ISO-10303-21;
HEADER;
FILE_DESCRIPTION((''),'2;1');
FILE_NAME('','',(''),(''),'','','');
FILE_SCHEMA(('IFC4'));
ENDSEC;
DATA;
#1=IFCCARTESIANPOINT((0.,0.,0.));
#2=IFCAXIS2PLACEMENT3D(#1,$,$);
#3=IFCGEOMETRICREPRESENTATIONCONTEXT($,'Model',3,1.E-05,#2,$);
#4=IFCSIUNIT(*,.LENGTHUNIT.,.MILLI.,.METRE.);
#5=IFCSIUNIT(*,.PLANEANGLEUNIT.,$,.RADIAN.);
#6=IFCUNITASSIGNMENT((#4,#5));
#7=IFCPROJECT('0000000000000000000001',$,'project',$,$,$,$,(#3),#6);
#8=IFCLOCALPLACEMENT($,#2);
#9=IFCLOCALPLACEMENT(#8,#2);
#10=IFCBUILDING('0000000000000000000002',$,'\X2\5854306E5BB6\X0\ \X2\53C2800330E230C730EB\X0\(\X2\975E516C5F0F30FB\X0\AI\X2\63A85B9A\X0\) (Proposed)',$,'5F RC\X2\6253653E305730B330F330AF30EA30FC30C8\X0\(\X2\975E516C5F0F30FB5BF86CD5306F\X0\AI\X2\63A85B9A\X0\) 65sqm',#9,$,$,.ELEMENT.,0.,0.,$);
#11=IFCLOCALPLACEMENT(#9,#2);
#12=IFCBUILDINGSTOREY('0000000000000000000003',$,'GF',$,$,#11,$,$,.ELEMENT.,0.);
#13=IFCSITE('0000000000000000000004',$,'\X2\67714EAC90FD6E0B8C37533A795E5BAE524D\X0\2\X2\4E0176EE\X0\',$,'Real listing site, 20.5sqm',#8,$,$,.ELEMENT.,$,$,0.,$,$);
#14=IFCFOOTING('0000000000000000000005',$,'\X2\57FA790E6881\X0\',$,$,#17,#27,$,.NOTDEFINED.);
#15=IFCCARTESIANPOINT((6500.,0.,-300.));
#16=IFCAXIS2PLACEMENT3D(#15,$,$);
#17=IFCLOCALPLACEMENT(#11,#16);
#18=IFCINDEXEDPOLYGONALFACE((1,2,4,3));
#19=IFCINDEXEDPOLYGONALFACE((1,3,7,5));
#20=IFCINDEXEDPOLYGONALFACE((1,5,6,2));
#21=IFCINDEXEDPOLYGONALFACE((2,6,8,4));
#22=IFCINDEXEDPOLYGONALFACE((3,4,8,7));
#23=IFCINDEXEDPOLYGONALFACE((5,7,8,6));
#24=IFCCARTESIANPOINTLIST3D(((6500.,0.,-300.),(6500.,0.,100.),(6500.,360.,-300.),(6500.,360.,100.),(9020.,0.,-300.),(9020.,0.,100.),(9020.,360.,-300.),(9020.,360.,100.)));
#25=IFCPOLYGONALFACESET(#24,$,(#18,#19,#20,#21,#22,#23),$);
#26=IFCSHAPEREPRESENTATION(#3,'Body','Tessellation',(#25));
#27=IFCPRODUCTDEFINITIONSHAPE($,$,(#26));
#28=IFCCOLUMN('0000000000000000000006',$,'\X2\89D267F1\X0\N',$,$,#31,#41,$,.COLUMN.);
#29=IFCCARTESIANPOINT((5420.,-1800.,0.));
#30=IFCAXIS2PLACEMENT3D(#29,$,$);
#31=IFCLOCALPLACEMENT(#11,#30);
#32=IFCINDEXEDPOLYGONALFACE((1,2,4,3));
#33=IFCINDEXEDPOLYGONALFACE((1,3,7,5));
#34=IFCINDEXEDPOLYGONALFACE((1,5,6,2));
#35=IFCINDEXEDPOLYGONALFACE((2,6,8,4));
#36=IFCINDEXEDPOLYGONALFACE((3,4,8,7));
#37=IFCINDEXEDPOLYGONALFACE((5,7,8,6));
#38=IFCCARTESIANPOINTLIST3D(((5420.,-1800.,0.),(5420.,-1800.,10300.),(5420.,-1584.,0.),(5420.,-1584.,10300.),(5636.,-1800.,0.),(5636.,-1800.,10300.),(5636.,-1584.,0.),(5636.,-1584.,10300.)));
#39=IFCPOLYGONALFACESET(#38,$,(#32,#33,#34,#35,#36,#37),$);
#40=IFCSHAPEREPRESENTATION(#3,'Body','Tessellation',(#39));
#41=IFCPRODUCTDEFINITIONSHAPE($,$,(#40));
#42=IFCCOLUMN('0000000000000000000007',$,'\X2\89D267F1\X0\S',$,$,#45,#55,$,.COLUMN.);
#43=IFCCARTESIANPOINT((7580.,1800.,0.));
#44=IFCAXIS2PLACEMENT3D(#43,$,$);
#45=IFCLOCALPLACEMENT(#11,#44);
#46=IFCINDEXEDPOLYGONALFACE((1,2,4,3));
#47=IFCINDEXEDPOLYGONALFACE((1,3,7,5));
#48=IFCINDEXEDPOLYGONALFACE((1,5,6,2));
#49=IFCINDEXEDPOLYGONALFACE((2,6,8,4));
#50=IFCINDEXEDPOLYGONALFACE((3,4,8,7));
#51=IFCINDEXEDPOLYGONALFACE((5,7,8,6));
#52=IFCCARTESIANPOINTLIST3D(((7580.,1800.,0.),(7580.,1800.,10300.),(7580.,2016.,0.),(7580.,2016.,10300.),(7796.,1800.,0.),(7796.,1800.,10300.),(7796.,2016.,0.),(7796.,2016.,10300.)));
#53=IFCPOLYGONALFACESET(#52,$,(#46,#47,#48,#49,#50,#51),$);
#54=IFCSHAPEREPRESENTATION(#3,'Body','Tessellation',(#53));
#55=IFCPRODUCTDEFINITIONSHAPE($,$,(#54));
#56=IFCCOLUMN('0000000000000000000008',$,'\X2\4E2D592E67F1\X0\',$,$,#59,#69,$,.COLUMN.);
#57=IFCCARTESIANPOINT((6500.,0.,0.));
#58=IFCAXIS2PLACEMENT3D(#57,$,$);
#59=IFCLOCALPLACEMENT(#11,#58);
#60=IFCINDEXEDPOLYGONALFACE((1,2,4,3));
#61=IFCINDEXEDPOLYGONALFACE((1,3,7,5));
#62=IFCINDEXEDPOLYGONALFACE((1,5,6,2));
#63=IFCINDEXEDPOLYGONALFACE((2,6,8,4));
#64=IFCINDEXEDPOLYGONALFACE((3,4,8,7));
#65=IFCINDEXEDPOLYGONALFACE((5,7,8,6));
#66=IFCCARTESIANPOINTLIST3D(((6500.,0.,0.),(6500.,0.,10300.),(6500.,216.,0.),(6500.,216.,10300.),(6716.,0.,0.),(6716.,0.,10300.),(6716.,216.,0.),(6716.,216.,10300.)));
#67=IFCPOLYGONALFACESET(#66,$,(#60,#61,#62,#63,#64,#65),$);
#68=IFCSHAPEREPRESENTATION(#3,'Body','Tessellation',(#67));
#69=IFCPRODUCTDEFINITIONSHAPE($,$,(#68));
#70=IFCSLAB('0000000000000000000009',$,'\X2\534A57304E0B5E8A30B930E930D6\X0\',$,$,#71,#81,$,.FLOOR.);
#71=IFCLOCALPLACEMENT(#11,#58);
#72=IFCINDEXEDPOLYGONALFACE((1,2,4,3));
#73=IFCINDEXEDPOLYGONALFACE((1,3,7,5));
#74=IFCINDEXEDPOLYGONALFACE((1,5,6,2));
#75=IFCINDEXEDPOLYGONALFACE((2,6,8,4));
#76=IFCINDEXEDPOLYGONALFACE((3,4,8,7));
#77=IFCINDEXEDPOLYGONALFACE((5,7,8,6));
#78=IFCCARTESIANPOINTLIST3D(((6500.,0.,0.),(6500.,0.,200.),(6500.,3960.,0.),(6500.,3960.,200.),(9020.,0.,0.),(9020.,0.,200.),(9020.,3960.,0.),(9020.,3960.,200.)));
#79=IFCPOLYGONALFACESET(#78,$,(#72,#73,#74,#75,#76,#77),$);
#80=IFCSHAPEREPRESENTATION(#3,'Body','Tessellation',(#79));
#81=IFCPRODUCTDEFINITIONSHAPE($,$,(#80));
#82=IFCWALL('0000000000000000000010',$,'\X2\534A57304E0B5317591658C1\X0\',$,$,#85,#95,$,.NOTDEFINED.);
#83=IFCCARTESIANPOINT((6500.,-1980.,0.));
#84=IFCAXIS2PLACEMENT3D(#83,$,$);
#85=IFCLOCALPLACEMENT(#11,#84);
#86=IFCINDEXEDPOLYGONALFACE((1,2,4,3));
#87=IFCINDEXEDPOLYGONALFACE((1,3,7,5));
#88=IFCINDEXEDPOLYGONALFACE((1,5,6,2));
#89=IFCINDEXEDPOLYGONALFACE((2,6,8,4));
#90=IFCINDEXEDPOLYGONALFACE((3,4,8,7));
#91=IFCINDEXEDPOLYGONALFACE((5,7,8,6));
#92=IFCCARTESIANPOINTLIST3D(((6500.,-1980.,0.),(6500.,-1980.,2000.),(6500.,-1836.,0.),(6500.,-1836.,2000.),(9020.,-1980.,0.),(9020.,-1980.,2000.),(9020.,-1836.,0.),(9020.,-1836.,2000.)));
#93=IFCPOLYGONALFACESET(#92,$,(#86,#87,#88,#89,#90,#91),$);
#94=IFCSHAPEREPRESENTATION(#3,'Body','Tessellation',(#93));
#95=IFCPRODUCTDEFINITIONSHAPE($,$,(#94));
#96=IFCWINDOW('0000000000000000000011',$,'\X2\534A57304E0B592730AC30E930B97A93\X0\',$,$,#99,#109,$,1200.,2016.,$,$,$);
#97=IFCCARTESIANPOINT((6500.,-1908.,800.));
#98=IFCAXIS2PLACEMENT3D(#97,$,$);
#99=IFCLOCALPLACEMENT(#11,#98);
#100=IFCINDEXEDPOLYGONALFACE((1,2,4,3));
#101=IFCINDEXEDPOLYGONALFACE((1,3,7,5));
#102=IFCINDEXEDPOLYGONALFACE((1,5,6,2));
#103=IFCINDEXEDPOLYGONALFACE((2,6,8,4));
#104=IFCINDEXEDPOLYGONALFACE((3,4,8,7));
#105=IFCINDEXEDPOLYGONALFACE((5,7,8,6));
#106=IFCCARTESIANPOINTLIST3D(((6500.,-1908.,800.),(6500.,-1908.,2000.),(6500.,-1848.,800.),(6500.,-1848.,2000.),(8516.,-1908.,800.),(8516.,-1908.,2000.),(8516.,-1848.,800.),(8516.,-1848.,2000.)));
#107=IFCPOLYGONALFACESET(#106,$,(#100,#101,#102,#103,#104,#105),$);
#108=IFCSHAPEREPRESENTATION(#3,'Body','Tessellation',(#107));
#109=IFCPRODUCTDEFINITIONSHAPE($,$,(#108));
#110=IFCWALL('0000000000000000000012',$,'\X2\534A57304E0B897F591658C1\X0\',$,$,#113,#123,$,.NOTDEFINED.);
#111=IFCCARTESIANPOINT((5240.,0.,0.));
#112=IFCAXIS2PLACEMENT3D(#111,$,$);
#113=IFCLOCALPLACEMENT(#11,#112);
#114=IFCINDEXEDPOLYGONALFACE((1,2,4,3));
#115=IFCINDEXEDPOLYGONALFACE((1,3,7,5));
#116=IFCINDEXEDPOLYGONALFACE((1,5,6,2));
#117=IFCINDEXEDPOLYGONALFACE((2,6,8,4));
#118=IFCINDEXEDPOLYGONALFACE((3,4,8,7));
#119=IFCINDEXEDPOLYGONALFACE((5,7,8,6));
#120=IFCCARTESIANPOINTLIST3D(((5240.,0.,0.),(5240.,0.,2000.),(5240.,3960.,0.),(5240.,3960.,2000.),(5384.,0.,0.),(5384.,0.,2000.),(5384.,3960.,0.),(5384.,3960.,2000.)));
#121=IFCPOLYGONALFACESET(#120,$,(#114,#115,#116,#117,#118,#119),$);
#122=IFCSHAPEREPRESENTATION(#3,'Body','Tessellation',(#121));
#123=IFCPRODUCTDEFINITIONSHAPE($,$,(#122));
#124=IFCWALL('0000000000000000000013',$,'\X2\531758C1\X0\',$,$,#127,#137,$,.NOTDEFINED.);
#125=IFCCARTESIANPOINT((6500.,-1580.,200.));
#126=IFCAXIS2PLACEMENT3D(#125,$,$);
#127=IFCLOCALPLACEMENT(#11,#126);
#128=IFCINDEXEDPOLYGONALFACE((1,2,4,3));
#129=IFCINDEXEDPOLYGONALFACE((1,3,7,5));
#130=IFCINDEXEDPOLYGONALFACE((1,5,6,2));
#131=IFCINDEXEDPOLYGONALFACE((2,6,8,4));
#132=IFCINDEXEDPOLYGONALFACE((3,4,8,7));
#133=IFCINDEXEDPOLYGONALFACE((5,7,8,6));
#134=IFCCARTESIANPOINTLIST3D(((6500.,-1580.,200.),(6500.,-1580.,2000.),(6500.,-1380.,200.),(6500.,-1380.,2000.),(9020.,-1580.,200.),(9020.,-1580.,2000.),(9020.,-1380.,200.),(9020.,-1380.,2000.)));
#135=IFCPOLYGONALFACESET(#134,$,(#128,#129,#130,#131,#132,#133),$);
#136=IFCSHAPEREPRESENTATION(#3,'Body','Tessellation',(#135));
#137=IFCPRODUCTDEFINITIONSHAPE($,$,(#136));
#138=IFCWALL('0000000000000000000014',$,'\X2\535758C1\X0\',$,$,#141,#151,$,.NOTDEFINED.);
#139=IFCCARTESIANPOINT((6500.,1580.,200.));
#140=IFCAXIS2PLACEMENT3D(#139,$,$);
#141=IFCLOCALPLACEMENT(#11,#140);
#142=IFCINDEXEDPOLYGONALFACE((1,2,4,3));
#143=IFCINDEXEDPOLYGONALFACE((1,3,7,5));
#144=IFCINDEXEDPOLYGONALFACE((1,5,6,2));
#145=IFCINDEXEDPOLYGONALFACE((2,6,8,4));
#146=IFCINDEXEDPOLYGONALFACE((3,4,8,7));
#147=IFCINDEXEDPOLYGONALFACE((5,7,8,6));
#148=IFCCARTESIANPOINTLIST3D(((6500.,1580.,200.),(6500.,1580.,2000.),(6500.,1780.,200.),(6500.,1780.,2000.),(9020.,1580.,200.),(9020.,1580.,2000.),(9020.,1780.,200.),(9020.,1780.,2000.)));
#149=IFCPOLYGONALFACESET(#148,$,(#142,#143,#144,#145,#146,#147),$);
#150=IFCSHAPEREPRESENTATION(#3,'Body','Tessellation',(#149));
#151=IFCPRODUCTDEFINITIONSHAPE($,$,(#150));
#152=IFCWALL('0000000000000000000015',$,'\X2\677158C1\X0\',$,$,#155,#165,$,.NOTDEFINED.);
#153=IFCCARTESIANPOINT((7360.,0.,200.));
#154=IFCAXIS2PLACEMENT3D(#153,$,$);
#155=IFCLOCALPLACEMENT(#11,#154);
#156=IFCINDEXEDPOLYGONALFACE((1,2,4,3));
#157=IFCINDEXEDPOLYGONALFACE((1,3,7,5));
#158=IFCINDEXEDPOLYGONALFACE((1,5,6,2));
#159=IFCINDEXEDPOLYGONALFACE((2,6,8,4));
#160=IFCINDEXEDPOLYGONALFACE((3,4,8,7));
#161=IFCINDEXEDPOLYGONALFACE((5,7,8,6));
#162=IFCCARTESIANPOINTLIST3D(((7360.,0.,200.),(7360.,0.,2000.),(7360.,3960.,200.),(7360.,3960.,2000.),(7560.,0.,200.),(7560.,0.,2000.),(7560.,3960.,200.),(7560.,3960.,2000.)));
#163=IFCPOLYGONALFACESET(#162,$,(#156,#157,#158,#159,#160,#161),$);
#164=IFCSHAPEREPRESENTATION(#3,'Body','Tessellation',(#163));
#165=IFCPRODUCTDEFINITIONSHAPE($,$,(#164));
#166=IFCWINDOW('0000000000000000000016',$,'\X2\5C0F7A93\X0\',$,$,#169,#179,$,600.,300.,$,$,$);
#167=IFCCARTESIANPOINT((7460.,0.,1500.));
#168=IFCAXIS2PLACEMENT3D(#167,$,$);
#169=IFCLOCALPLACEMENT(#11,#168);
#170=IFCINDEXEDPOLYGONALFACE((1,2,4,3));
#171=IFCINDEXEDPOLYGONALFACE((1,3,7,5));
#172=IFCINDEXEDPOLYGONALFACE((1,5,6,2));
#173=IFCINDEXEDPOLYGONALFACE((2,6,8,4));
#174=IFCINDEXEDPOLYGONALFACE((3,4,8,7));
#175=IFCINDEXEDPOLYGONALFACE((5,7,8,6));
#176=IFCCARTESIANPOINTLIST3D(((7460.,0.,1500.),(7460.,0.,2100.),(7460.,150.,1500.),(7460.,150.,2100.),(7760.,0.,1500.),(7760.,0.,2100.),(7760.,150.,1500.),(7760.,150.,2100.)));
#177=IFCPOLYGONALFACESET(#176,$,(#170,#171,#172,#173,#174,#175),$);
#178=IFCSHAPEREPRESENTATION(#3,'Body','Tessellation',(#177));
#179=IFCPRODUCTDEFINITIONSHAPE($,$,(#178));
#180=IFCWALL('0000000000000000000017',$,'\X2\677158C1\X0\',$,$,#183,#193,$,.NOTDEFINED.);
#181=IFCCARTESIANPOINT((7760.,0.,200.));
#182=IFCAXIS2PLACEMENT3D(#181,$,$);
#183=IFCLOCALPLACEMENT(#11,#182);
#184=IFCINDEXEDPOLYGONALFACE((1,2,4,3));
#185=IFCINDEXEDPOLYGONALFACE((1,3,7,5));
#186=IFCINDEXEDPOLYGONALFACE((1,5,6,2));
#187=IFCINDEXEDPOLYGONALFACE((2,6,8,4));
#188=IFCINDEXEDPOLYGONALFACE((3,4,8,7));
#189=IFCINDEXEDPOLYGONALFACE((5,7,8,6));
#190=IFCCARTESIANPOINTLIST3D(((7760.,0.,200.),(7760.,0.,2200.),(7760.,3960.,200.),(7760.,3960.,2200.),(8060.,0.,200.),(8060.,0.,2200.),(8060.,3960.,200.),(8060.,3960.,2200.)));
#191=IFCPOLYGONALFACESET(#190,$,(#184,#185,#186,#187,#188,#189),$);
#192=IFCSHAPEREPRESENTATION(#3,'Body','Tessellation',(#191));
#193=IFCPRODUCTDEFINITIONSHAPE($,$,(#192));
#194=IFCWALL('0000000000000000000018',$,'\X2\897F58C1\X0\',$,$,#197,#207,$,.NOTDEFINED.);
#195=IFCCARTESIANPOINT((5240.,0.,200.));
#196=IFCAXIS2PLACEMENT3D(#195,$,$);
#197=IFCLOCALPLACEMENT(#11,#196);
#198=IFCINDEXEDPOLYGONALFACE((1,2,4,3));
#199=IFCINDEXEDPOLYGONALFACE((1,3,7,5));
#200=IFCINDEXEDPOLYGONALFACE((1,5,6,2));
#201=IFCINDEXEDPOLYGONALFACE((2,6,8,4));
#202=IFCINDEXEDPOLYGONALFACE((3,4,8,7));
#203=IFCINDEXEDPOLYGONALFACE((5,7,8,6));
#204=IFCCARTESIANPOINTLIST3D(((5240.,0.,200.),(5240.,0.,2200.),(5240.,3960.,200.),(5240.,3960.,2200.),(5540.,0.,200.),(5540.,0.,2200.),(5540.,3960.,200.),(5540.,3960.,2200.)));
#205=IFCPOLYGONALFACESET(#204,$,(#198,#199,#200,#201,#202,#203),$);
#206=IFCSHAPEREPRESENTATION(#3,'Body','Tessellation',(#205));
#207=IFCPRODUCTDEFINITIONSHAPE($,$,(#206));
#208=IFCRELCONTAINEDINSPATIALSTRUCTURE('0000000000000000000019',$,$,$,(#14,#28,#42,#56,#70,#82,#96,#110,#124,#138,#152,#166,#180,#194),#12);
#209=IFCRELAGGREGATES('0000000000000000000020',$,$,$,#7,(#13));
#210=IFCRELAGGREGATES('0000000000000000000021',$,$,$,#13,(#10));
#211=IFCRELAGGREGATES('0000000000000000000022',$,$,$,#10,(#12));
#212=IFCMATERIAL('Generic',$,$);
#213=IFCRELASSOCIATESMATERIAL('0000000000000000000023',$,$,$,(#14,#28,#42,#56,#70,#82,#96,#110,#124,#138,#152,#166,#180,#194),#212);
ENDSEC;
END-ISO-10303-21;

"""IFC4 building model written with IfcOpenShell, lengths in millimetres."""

from ifc_helpers import new_model, si_unit, frame, frame_2d, origin, place, context, project, spatial, rectangle, extrude, material, element, fill, save


model = new_model("IFC4")

# Units and contexts
model_context = context("Model", 3, precision=1e-05, world=origin())
ifc_project = project(units=[si_unit("LENGTHUNIT", "METRE", prefix="MILLI"), si_unit("PLANEANGLEUNIT", "RADIAN")], contexts=[model_context])

# Site, building, storey
site_placement = place(None, origin())
site = spatial("IfcSite", under=ifc_project, at=site_placement, Name="東京都渋谷区神宮前2丁目", ObjectType="Real listing site, 20.5sqm", CompositionType="ELEMENT", RefElevation=0.0)
building_placement = place(site_placement, origin())
building = spatial("IfcBuilding", under=site, at=building_placement, Name="塔の家 参考モデル(非公式・AI推定) (Proposed)", ObjectType="5F RC打放しコンクリート(非公式・寸法はAI推定) 65sqm", CompositionType="ELEMENT", ElevationOfRefHeight=0.0, ElevationOfTerrain=0.0)
storey_placement = place(building_placement, origin())
storey = spatial("IfcBuildingStorey", under=building, at=storey_placement, Name="GF", CompositionType="ELEMENT", Elevation=0.0)

# Footing
ifc_material = material(Name="Generic")
footing_1_placement = place(storey_placement, frame((6500.0, 0.0, -300.0)))
element("IfcFooting", 1, at=footing_1_placement, inside=storey, material=ifc_material, Name="基礎梁", PredefinedType="NOTDEFINED", context=model_context, shape_type="SweptSolid", body=[
    extrude(rectangle(XDim=2520.0, YDim=360.0, at=frame_2d((1260.0, 180.0))), frame((6500.0, 0.0, -300.0)), (0.0, 0.0, 1.0), 400.0),
])

# Columns
column_1_placement = place(storey_placement, frame((5420.0, -1800.0, 0.0)))
element("IfcColumn", 2, at=column_1_placement, inside=storey, material=ifc_material, Name="角柱N", PredefinedType="COLUMN", context=model_context, shape_type="SweptSolid", body=[
    extrude(rectangle(XDim=216.0, YDim=216.0, at=frame_2d((108.0, 108.0))), frame((5420.0, -1800.0, 0.0)), (0.0, 0.0, 1.0), 10300.0),
])
column_2_placement = place(storey_placement, frame((7580.0, 1800.0, 0.0)))
element("IfcColumn", 3, at=column_2_placement, inside=storey, material=ifc_material, Name="角柱S", PredefinedType="COLUMN", context=model_context, shape_type="SweptSolid", body=[
    extrude(rectangle(XDim=216.0, YDim=216.0, at=frame_2d((108.0, 108.0))), frame((7580.0, 1800.0, 0.0)), (0.0, 0.0, 1.0), 10300.0),
])
column_3_placement = place(storey_placement, frame((6500.0, 0.0, 0.0)))
element("IfcColumn", 4, at=column_3_placement, inside=storey, material=ifc_material, Name="中央柱", PredefinedType="COLUMN", context=model_context, shape_type="SweptSolid", body=[
    extrude(rectangle(XDim=216.0, YDim=216.0, at=frame_2d((108.0, 108.0))), frame((6500.0, 0.0, 0.0)), (0.0, 0.0, 1.0), 10300.0),
])

# Slab
slab_placement = place(storey_placement, frame((6500.0, 0.0, 0.0)))
element("IfcSlab", 5, at=slab_placement, inside=storey, material=ifc_material, Name="半地下床スラブ", PredefinedType="FLOOR", context=model_context, shape_type="SweptSolid", body=[
    extrude(rectangle(XDim=2520.0, YDim=3960.0, at=frame_2d((1260.0, 1980.0))), frame((6500.0, 0.0, 0.0)), (0.0, 0.0, 1.0), 200.0),
])

# Wall, opening, window
wall_1_placement = place(storey_placement, frame((6500.0, -1980.0, 0.0)))
wall_1 = element("IfcWall", 6, at=wall_1_placement, inside=storey, material=ifc_material, Name="半地下北外壁", PredefinedType="NOTDEFINED", context=model_context, shape_type="SweptSolid", body=[
    extrude(rectangle(XDim=2520.0, YDim=144.0, at=frame_2d((1260.0, 72.0))), frame((6500.0, -1980.0, 0.0)), (0.0, 0.0, 1.0), 2000.0),
])
opening_1_placement = place(storey_placement, frame((6500.0, -1908.0, 800.0)))
opening_1 = element("IfcOpeningElement", 7, at=opening_1_placement, cuts=wall_1, PredefinedType="NOTDEFINED", context=model_context, shape_type="SweptSolid", body=[
    extrude(rectangle(XDim=2016.0, YDim=60.0, at=frame_2d((1008.0, 30.0))), frame((6500.0, -1908.0, 800.0)), (0.0, 0.0, 1.0), 1200.0),
])
window_1_placement = place(storey_placement, frame((6500.0, -1908.0, 800.0)))
window_1 = element("IfcWindow", 8, at=window_1_placement, inside=storey, material=ifc_material, Name="半地下大ガラス窓", OverallHeight=1200.0, OverallWidth=2016.0, context=model_context, shape_type="SweptSolid", body=[
    extrude(rectangle(XDim=2016.0, YDim=60.0, at=frame_2d((1008.0, 30.0))), frame((6500.0, -1908.0, 800.0)), (0.0, 0.0, 1.0), 1200.0),
])
fill(opening_1, window_1)

# Walls
wall_2_placement = place(storey_placement, frame((5240.0, 0.0, 0.0)))
element("IfcWall", 9, at=wall_2_placement, inside=storey, material=ifc_material, Name="半地下西外壁", PredefinedType="NOTDEFINED", context=model_context, shape_type="SweptSolid", body=[
    extrude(rectangle(XDim=144.0, YDim=3960.0, at=frame_2d((72.0, 1980.0))), frame((5240.0, 0.0, 0.0)), (0.0, 0.0, 1.0), 2000.0),
])
wall_3_placement = place(storey_placement, frame((6500.0, -1580.0, 200.0)))
element("IfcWall", 10, at=wall_3_placement, inside=storey, material=ifc_material, Name="北壁", PredefinedType="NOTDEFINED", context=model_context, shape_type="SweptSolid", body=[
    extrude(rectangle(XDim=2520.0, YDim=200.0, at=frame_2d((1260.0, 100.0))), frame((6500.0, -1580.0, 200.0)), (0.0, 0.0, 1.0), 1800.0),
])
wall_4_placement = place(storey_placement, frame((6500.0, 1580.0, 200.0)))
element("IfcWall", 11, at=wall_4_placement, inside=storey, material=ifc_material, Name="南壁", PredefinedType="NOTDEFINED", context=model_context, shape_type="SweptSolid", body=[
    extrude(rectangle(XDim=2520.0, YDim=200.0, at=frame_2d((1260.0, 100.0))), frame((6500.0, 1580.0, 200.0)), (0.0, 0.0, 1.0), 1800.0),
])

# Wall, opening, window
wall_5_placement = place(storey_placement, frame((7360.0, 0.0, 200.0)))
wall_5 = element("IfcWall", 12, at=wall_5_placement, inside=storey, material=ifc_material, Name="東壁", PredefinedType="NOTDEFINED", context=model_context, shape_type="SweptSolid", body=[
    extrude(rectangle(XDim=200.0, YDim=3960.0, at=frame_2d((100.0, 1980.0))), frame((7360.0, 0.0, 200.0)), (0.0, 0.0, 1.0), 1800.0),
])
opening_2_placement = place(storey_placement, frame((7460.0, 0.0, 1500.0)))
opening_2 = element("IfcOpeningElement", 13, at=opening_2_placement, cuts=wall_5, PredefinedType="NOTDEFINED", context=model_context, shape_type="SweptSolid", body=[
    extrude(rectangle(XDim=300.0, YDim=150.0, at=frame_2d((150.0, 75.0))), frame((7460.0, 0.0, 1500.0)), (0.0, 0.0, 1.0), 600.0),
])
window_2_placement = place(storey_placement, frame((7460.0, 0.0, 1500.0)))
window_2 = element("IfcWindow", 14, at=window_2_placement, inside=storey, material=ifc_material, Name="小窓", OverallHeight=600.0, OverallWidth=300.0, context=model_context, shape_type="SweptSolid", body=[
    extrude(rectangle(XDim=300.0, YDim=150.0, at=frame_2d((150.0, 75.0))), frame((7460.0, 0.0, 1500.0)), (0.0, 0.0, 1.0), 600.0),
])
fill(opening_2, window_2)

# Walls
wall_6_placement = place(storey_placement, frame((7760.0, 0.0, 200.0)))
element("IfcWall", 15, at=wall_6_placement, inside=storey, material=ifc_material, Name="東壁", PredefinedType="NOTDEFINED", context=model_context, shape_type="SweptSolid", body=[
    extrude(rectangle(XDim=300.0, YDim=3960.0, at=frame_2d((150.0, 1980.0))), frame((7760.0, 0.0, 200.0)), (0.0, 0.0, 1.0), 2000.0),
])
wall_7_placement = place(storey_placement, frame((5240.0, 0.0, 200.0)))
element("IfcWall", 16, at=wall_7_placement, inside=storey, material=ifc_material, Name="西壁", PredefinedType="NOTDEFINED", context=model_context, shape_type="SweptSolid", body=[
    extrude(rectangle(XDim=300.0, YDim=3960.0, at=frame_2d((150.0, 1980.0))), frame((5240.0, 0.0, 200.0)), (0.0, 0.0, 1.0), 2000.0),
])

save(model, "model.ifc")
